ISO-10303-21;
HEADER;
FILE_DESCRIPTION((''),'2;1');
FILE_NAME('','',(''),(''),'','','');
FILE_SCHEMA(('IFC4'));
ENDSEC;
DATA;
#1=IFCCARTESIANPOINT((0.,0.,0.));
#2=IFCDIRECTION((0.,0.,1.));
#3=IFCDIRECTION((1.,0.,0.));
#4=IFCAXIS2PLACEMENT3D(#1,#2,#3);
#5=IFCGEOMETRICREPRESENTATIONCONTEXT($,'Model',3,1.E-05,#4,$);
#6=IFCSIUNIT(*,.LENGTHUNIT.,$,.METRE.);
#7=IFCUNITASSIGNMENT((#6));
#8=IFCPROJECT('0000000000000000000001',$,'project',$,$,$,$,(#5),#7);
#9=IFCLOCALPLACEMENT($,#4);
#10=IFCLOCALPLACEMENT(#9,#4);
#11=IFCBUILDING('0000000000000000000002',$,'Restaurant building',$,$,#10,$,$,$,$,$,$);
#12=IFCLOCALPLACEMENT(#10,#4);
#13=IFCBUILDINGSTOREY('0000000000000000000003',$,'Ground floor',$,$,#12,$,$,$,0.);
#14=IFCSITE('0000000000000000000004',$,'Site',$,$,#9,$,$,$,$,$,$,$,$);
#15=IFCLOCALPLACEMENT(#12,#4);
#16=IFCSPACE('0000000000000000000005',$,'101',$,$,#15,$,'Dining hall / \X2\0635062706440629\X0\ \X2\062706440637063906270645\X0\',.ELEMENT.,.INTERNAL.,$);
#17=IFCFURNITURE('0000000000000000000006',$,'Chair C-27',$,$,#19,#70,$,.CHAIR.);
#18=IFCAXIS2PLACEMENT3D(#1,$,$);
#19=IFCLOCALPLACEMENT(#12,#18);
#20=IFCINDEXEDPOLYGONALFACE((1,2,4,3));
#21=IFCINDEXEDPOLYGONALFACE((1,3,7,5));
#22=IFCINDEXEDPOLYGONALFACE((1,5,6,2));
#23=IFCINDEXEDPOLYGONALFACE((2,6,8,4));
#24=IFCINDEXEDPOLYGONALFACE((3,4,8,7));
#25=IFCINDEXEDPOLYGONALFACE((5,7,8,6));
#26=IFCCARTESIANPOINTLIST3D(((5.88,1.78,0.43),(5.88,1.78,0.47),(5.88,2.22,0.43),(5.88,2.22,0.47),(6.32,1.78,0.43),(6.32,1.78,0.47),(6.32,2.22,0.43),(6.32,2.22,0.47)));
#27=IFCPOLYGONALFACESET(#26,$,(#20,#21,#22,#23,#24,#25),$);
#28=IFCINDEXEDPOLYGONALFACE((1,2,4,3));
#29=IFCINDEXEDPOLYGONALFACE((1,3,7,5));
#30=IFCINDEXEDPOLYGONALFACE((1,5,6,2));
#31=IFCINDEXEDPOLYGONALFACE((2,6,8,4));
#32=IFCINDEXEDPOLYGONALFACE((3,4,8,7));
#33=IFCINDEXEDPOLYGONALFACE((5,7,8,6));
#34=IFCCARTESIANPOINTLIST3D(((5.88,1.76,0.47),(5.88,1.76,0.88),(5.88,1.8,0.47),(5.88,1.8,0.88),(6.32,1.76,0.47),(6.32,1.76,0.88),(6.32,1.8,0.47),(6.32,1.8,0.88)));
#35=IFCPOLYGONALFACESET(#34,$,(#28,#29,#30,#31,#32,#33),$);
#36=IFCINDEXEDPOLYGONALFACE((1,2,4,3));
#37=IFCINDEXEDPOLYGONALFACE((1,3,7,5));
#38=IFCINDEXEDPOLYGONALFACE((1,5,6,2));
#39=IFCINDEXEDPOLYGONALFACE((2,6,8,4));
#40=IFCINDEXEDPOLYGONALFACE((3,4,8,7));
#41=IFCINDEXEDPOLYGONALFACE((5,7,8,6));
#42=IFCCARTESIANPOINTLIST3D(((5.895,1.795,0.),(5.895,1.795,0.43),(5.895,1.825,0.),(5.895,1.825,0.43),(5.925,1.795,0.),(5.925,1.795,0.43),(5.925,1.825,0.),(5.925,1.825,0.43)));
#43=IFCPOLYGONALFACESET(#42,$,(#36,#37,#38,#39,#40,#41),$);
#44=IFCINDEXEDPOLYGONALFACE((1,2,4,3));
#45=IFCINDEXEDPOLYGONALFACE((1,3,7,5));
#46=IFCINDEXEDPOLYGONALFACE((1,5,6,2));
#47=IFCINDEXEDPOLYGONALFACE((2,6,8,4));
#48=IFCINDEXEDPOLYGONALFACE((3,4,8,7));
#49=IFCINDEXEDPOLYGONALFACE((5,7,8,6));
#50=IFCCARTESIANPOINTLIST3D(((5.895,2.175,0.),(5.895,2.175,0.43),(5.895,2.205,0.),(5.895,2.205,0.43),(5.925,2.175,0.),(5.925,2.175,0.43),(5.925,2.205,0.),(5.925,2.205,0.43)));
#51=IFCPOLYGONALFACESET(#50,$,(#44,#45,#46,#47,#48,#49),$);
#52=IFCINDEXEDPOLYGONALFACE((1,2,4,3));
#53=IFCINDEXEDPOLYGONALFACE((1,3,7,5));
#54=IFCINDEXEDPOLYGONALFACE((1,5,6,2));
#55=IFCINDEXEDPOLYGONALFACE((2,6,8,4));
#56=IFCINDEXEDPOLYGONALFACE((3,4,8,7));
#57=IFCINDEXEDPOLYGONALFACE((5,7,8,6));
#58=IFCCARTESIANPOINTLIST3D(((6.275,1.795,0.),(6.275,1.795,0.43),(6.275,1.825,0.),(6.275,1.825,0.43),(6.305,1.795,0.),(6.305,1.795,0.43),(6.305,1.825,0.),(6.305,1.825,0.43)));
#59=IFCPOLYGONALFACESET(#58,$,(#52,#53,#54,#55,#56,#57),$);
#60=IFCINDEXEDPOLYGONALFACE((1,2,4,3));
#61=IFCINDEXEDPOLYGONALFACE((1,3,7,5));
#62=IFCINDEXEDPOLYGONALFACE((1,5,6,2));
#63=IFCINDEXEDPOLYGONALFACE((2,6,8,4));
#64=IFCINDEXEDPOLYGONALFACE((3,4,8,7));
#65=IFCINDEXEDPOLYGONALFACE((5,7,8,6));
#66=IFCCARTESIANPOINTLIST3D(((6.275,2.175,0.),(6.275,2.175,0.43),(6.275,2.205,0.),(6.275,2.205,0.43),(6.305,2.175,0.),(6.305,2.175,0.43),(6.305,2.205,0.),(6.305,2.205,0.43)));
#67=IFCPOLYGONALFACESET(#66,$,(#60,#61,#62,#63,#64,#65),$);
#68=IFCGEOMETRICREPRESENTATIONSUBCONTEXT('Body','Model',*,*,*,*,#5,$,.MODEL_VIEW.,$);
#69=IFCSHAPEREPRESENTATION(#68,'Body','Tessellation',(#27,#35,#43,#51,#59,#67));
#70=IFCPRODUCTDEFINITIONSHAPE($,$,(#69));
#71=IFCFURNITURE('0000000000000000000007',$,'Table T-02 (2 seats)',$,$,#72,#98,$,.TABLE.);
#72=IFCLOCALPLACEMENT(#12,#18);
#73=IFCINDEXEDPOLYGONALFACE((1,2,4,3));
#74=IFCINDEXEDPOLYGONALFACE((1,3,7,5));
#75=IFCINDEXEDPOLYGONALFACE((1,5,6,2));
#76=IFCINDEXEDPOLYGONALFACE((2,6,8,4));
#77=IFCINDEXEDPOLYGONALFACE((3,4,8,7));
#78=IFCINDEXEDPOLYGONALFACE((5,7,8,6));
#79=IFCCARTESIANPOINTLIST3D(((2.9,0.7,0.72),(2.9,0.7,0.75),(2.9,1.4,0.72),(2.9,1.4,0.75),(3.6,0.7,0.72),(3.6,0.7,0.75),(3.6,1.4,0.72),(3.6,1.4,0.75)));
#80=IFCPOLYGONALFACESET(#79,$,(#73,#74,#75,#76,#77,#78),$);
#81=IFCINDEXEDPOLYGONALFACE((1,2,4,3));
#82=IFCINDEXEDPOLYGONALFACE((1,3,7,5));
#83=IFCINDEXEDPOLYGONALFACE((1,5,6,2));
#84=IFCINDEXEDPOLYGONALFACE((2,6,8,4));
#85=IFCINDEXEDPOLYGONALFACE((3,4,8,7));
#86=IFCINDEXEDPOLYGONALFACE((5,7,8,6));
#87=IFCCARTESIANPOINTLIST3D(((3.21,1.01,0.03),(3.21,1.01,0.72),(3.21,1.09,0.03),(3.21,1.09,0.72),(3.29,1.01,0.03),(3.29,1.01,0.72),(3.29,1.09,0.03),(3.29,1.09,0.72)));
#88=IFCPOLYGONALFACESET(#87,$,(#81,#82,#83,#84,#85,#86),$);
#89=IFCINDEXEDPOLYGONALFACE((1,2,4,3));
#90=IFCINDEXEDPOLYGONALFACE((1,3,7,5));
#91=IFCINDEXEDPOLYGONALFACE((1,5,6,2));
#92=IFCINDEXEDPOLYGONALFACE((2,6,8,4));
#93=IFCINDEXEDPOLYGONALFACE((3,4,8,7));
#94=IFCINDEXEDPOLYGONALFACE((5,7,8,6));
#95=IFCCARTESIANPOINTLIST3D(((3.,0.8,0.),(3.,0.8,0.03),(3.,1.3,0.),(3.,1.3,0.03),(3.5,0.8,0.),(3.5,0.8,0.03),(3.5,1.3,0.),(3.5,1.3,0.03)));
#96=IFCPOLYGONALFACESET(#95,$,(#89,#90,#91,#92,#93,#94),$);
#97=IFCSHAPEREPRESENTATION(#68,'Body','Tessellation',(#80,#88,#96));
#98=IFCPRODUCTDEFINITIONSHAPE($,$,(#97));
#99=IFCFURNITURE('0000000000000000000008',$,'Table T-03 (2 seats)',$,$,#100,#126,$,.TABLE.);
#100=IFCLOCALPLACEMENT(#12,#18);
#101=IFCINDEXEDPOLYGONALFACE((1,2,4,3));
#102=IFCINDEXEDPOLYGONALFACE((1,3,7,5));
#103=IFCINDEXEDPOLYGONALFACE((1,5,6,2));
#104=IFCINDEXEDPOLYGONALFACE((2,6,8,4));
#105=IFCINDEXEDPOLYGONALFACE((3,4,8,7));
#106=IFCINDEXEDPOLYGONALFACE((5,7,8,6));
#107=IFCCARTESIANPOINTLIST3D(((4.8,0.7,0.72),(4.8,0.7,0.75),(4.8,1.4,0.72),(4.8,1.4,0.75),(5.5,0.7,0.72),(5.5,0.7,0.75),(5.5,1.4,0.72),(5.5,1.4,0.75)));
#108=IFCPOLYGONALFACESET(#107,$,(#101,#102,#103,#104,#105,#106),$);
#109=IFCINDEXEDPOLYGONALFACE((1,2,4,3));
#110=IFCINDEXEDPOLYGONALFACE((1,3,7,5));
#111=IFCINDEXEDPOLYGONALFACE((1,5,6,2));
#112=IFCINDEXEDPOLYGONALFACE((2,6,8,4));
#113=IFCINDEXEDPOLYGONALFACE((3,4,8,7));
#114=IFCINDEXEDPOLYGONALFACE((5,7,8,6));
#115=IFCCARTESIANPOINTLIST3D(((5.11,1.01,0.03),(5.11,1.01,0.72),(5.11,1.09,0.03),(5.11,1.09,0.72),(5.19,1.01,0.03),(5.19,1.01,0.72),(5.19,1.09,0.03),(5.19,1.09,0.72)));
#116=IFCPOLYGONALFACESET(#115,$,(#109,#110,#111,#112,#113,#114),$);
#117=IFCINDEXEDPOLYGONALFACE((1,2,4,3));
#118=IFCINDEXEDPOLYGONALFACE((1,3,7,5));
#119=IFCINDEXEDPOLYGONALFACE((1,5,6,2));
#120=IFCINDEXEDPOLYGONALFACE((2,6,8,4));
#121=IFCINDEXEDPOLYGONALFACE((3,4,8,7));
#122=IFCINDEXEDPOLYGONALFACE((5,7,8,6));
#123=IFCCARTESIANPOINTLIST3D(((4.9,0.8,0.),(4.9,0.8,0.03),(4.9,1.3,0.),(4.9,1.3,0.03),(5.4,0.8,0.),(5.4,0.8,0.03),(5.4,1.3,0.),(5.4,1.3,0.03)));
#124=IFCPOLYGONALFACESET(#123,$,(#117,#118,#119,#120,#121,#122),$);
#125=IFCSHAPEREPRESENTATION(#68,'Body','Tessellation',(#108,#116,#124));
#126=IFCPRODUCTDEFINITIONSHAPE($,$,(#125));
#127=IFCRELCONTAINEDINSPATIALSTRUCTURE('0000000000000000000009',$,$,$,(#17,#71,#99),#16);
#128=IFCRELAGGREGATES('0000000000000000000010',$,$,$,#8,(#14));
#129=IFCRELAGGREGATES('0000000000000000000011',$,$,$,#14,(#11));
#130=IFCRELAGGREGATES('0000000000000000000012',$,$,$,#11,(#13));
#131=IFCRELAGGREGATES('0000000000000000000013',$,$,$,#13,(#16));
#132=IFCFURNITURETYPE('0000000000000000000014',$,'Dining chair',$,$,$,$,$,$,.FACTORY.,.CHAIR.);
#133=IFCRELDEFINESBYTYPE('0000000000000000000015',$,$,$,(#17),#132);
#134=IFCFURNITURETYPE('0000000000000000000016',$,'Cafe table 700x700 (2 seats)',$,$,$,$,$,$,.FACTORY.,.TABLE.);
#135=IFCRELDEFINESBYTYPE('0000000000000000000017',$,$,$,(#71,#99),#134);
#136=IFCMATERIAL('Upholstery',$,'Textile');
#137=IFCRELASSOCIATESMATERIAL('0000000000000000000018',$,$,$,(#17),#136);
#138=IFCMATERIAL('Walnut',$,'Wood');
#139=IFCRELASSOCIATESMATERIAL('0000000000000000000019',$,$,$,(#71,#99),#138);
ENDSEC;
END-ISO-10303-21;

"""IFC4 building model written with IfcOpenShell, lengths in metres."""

from ifc_helpers import new_model, si_unit, frame, origin, origin_with_axes, origin_2d, place, context, subcontext, project, spatial, rectangle, extrude, source, transform, mapped, material, type_object, type_shapes, element, save


model = new_model("IFC4")

# Units and contexts
model_context = context("Model", 3, precision=1e-05, world=origin_with_axes())
body_context = subcontext(model_context, "Body", "Model", "MODEL_VIEW")
ifc_project = project(units=[si_unit("LENGTHUNIT", "METRE")], contexts=[model_context])

# Site, building, storey, space
site_placement = place(None, origin_with_axes())
site = spatial("IfcSite", under=ifc_project, at=site_placement, Name="Site")
building_placement = place(site_placement, origin_with_axes())
building = spatial("IfcBuilding", under=site, at=building_placement, Name="Restaurant building")
storey_placement = place(building_placement, origin_with_axes())
storey = spatial("IfcBuildingStorey", under=building, at=storey_placement, Name="Ground floor", Elevation=0.0)
space_placement = place(storey_placement, origin_with_axes())
space = spatial("IfcSpace", under=storey, at=space_placement, Name="101", LongName="Dining hall / صالة الطعام", CompositionType="ELEMENT", PredefinedType="INTERNAL")

# Furniture
ifc_material_1 = material(Name="Upholstery", Category="Textile")
furniture_type_1 = type_object("IfcFurnitureType", Name="Dining chair", AssemblyPlace="FACTORY", PredefinedType="CHAIR")
shared_shape_1 = source(origin(), body_context, "Body", "SweptSolid", [
    extrude(rectangle(XDim=0.44, YDim=0.44, at=origin_2d()), frame((0.0, 0.0, 0.43)), (0.0, 0.0, 1.0), 0.04),
    extrude(rectangle(XDim=0.44, YDim=0.04, at=origin_2d()), frame((0.0, -0.22, 0.47)), (0.0, 0.0, 1.0), 0.41),
    extrude(rectangle(XDim=0.03, YDim=0.03, at=origin_2d()), frame((-0.19, -0.19, 0.0)), (0.0, 0.0, 1.0), 0.43),
    extrude(rectangle(XDim=0.03, YDim=0.03, at=origin_2d()), frame((-0.19, 0.19, 0.0)), (0.0, 0.0, 1.0), 0.43),
    extrude(rectangle(XDim=0.03, YDim=0.03, at=origin_2d()), frame((0.19, -0.19, 0.0)), (0.0, 0.0, 1.0), 0.43),
    extrude(rectangle(XDim=0.03, YDim=0.03, at=origin_2d()), frame((0.19, 0.19, 0.0)), (0.0, 0.0, 1.0), 0.43),
])
type_shapes(furniture_type_1, [shared_shape_1])
for number, where, name in (
    (1, (6.1, 2.0, 0.0), "Chair C-27"),
):
    element("IfcFurniture", number, at=place(storey_placement, frame(where)), inside=space, type_object=furniture_type_1, material=ifc_material_1, Name=name, PredefinedType="CHAIR", context=body_context, shape_type="MappedRepresentation", body=[
        mapped(shared_shape_1, transform((0.0, 0.0, 0.0))),
    ])
ifc_material_2 = material(Name="Walnut", Category="Wood")
furniture_type_2 = type_object("IfcFurnitureType", Name="Cafe table 700x700 (2 seats)", AssemblyPlace="FACTORY", PredefinedType="TABLE")
shared_shape_2 = source(origin(), body_context, "Body", "SweptSolid", [
    extrude(rectangle(XDim=0.7, YDim=0.7, at=origin_2d()), frame((0.0, 0.0, 0.72)), (0.0, 0.0, 1.0), 0.03),
    extrude(rectangle(XDim=0.08, YDim=0.08, at=origin_2d()), frame((0.0, 0.0, 0.03)), (0.0, 0.0, 1.0), 0.69),
    extrude(rectangle(XDim=0.5, YDim=0.5, at=origin_2d()), origin(), (0.0, 0.0, 1.0), 0.03),
])
type_shapes(furniture_type_2, [shared_shape_2])
for number, where, name in (
    (2, (3.25, 1.05, 0.0), "Table T-02 (2 seats)"),
    (3, (5.15, 1.05, 0.0), "Table T-03 (2 seats)"),
):
    element("IfcFurniture", number, at=place(storey_placement, frame(where)), inside=space, type_object=furniture_type_2, material=ifc_material_2, Name=name, PredefinedType="TABLE", context=body_context, shape_type="MappedRepresentation", body=[
        mapped(shared_shape_2, transform((0.0, 0.0, 0.0))),
    ])

save(model, "model.ifc")
